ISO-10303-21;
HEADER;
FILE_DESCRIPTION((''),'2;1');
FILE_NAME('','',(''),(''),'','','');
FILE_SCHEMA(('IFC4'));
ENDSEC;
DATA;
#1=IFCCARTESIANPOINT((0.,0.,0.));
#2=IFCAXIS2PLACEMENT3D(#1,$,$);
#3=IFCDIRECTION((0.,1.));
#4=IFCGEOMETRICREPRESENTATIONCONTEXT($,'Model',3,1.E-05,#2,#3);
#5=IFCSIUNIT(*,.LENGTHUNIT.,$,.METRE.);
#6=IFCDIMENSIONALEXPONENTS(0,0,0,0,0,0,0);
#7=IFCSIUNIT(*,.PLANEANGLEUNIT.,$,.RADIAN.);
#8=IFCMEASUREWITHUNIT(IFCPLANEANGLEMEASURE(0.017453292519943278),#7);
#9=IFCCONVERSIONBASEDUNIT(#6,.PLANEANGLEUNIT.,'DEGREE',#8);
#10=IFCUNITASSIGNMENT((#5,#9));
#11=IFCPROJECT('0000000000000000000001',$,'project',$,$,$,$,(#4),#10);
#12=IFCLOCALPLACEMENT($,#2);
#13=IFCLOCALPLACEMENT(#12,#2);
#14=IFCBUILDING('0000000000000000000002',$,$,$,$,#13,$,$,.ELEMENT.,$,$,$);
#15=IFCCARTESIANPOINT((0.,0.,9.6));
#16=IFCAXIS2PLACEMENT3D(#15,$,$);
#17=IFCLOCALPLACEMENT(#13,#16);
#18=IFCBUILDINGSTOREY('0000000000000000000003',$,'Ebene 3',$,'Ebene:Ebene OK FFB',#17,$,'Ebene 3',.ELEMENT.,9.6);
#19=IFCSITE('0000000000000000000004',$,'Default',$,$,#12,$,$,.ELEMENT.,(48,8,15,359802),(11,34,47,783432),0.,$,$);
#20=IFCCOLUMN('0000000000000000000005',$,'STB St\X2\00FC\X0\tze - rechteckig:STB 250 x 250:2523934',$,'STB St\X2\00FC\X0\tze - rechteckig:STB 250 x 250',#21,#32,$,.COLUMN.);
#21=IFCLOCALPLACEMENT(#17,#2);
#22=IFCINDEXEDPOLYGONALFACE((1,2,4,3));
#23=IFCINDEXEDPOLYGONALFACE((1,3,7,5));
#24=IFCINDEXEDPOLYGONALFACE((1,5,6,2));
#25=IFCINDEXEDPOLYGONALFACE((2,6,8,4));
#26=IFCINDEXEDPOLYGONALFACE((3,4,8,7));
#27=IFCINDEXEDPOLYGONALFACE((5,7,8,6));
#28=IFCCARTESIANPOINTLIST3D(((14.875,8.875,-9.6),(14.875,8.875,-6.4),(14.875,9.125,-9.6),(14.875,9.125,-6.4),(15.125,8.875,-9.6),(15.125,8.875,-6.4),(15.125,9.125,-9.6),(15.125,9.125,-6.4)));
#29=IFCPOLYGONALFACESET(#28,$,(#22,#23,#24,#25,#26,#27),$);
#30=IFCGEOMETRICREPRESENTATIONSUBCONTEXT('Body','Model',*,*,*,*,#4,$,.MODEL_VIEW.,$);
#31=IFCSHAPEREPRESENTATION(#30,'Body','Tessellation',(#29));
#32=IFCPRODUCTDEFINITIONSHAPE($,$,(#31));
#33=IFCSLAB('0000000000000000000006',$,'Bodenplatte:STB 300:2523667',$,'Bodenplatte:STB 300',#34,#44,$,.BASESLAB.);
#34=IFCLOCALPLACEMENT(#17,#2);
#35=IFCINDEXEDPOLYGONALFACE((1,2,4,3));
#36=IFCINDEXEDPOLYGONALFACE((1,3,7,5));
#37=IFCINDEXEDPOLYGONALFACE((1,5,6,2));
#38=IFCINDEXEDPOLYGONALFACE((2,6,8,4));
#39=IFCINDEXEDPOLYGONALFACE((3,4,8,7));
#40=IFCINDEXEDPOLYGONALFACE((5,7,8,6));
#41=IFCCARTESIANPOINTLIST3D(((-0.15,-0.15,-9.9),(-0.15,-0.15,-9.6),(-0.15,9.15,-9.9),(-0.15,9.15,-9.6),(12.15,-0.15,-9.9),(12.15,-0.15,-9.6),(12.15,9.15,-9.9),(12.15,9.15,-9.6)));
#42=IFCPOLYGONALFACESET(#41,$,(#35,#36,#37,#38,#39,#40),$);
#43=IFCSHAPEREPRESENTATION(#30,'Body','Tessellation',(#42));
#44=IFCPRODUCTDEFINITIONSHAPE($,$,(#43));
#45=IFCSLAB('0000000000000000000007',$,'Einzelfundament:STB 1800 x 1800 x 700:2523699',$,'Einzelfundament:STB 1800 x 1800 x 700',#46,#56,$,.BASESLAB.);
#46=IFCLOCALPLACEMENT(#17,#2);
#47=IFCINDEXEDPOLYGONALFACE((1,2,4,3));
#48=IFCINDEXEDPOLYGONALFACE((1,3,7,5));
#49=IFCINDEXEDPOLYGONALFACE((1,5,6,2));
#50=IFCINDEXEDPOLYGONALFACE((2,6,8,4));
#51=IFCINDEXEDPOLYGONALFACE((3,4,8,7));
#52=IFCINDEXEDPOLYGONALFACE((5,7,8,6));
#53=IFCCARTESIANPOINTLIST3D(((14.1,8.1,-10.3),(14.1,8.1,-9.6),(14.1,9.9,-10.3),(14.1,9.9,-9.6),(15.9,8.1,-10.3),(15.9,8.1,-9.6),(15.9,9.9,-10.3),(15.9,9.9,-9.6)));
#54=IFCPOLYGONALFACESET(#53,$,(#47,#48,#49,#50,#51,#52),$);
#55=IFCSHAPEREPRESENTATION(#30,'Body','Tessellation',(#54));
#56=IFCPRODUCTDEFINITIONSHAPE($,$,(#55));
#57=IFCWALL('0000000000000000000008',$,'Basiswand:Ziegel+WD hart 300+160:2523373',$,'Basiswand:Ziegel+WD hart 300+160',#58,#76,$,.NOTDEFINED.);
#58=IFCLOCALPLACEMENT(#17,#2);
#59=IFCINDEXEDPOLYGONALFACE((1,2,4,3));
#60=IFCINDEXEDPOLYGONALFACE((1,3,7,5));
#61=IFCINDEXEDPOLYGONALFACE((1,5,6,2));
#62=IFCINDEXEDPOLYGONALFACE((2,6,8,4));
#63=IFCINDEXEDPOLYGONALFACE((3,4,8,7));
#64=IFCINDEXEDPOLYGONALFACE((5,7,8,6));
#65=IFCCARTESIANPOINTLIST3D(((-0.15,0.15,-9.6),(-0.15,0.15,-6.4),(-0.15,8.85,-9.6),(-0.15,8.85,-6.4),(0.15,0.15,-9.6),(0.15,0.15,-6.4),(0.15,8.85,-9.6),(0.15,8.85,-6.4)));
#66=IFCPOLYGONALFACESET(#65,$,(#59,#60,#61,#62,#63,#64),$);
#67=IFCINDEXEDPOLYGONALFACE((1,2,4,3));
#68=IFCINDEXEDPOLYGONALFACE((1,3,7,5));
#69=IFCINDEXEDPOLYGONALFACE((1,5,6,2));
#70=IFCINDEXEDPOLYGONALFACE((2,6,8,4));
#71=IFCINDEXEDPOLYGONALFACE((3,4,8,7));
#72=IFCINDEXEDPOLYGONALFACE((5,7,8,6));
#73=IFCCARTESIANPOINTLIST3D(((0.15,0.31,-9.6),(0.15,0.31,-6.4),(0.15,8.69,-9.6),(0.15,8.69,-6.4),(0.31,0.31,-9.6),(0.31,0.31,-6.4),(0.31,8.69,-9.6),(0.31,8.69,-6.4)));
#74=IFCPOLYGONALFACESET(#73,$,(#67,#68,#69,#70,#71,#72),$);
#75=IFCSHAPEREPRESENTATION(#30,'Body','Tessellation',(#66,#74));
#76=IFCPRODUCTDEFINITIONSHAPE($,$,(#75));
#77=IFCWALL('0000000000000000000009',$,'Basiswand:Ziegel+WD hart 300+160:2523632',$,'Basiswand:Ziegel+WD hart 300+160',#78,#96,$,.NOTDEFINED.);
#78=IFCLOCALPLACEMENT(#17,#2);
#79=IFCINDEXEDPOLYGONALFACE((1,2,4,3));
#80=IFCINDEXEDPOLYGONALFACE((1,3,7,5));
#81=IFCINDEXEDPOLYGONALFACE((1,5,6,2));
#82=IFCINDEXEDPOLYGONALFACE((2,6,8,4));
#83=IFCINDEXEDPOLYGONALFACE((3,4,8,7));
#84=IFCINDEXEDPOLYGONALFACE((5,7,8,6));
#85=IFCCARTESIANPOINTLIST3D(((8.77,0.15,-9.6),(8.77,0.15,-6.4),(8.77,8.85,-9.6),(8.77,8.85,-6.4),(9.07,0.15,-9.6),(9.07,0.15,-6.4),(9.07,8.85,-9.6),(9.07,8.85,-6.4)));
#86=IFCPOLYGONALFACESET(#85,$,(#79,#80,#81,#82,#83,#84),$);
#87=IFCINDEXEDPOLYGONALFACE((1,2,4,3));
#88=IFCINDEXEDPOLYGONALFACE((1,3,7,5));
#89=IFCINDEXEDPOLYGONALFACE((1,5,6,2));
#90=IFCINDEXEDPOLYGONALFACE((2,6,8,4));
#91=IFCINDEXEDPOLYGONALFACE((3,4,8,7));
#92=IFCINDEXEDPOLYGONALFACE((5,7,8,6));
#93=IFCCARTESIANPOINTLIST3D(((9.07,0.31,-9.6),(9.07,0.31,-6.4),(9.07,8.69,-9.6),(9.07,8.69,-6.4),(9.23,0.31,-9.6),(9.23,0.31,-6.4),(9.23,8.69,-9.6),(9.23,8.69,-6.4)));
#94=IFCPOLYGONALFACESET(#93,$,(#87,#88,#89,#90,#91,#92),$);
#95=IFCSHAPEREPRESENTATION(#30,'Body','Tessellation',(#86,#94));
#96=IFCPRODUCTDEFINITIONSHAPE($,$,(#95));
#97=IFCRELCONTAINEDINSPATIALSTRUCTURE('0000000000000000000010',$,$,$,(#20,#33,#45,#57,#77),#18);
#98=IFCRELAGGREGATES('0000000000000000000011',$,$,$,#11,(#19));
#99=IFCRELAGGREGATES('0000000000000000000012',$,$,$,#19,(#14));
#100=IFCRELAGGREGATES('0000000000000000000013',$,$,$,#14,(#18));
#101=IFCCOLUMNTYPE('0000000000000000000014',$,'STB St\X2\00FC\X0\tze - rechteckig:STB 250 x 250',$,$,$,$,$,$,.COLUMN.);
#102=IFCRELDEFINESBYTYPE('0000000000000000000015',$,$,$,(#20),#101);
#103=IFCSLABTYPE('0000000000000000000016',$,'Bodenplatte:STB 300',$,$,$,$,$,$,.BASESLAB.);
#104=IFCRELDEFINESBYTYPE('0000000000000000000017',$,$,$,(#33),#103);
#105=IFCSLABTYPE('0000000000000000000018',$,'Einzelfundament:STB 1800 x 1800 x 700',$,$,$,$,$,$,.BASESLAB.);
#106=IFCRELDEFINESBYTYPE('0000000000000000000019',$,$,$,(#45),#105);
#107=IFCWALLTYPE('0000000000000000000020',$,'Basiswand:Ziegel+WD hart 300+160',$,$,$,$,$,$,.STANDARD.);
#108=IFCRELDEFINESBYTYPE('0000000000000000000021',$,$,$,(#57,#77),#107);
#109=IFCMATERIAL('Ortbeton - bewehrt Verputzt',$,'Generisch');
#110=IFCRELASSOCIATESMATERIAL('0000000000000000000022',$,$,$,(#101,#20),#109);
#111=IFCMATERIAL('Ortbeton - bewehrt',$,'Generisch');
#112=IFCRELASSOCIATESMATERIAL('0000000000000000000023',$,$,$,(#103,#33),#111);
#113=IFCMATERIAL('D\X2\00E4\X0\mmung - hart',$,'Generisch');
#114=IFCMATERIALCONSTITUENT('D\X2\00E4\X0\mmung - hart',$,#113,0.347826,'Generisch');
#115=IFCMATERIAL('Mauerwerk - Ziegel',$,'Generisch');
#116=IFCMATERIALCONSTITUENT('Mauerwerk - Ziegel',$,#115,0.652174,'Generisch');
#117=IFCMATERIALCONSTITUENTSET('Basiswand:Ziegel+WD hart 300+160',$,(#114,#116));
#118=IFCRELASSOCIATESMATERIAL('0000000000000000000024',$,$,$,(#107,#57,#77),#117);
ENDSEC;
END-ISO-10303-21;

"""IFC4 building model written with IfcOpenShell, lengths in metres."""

from ifc_helpers import new_model, entity, si_unit, converted_unit, direction, frame, origin, place, context, subcontext, project, spatial, indexed_curve, outline, extrude, source, transform, mapped, material, constituent, constituent_set, type_object, type_shapes, element, save


model = new_model("IFC4")

# Units and contexts
model_context = context("Model", 3, precision=1e-05, world=origin(), true_north=direction((0.0, 1.0)))
body_context = subcontext(model_context, "Body", "Model", "MODEL_VIEW")
ifc_project = project(units=[si_unit("LENGTHUNIT", "METRE"), converted_unit("PLANEANGLEUNIT", "DEGREE", entity("IfcPlaneAngleMeasure", 0.017453292519943278), si_unit("PLANEANGLEUNIT", "RADIAN"), dimensions=[0, 0, 0, 0, 0, 0, 0])], contexts=[model_context])

# Site, building, storey
site_placement = place(None, origin())
site = spatial("IfcSite", under=ifc_project, at=site_placement, Name="Default", CompositionType="ELEMENT", RefLatitude=(48, 8, 15, 359802), RefLongitude=(11, 34, 47, 783432), RefElevation=0.0)
building_placement = place(site_placement, origin())
building = spatial("IfcBuilding", under=site, at=building_placement, CompositionType="ELEMENT")
storey_placement = place(building_placement, frame((0.0, 0.0, 9.6)))
storey = spatial("IfcBuildingStorey", under=building, at=storey_placement, Name="Ebene 3", ObjectType="Ebene:Ebene OK FFB", LongName="Ebene 3", CompositionType="ELEMENT", Elevation=9.6)

# Column
ifc_material_1 = material(Name="Ortbeton - bewehrt Verputzt", Category="Generisch")
column_type = type_object("IfcColumnType", Name="STB Stütze - rechteckig:STB 250 x 250", PredefinedType="COLUMN", material=ifc_material_1)
shared_shape = source(origin(), body_context, "Body", "SweptSolid", [
    extrude(outline(indexed_curve([(-0.125, -0.125), (0.125, -0.125), (0.125, 0.125), (-0.125, 0.125), (-0.125, -0.125)], self_intersect=False)), frame((0.0, 0.0, 0.0), z_axis=(0.0, 0.0, 1.0), x_axis=(-1.0, 0.0, 0.0)), (0.0, 0.0, 1.0), 3.2),
])
type_shapes(column_type, [shared_shape])
column_placement = place(storey_placement, frame((15.0, 9.0, -9.6)))
element("IfcColumn", 1, at=column_placement, inside=storey, type_object=column_type, material=ifc_material_1, Name="STB Stütze - rechteckig:STB 250 x 250:2523934", ObjectType="STB Stütze - rechteckig:STB 250 x 250", PredefinedType="COLUMN", context=body_context, shape_type="MappedRepresentation", body=[
    mapped(shared_shape, transform((0.0, 0.0, 0.0), scale=1.0)),
])

# Slabs
ifc_material_2 = material(Name="Ortbeton - bewehrt", Category="Generisch")
slab_type_1 = type_object("IfcSlabType", Name="Bodenplatte:STB 300", PredefinedType="BASESLAB", material=ifc_material_2)
slab_1_placement = place(storey_placement, origin())
element("IfcSlab", 2, at=slab_1_placement, inside=storey, type_object=slab_type_1, material=ifc_material_2, Name="Bodenplatte:STB 300:2523667", ObjectType="Bodenplatte:STB 300", PredefinedType="BASESLAB", context=body_context, shape_type="SweptSolid", body=[
    extrude(outline(indexed_curve([(-4.65, -6.15), (4.65, -6.15), (4.65, 6.15), (-4.65, 6.15), (-4.65, -6.15)], self_intersect=False)), frame((6.0, 4.5, -9.6), z_axis=(0.0, 0.0, -1.0), x_axis=(0.0, 1.0, 0.0)), (0.0, 0.0, 1.0), 0.3),
])
slab_type_2 = type_object("IfcSlabType", Name="Einzelfundament:STB 1800 x 1800 x 700", PredefinedType="BASESLAB")
slab_2_placement = place(storey_placement, origin())
element("IfcSlab", 3, at=slab_2_placement, inside=storey, type_object=slab_type_2, Name="Einzelfundament:STB 1800 x 1800 x 700:2523699", ObjectType="Einzelfundament:STB 1800 x 1800 x 700", PredefinedType="BASESLAB", context=body_context, shape_type="SweptSolid", body=[
    extrude(outline(indexed_curve([(-0.9, -0.9), (0.9, -0.9), (0.9, 0.9), (-0.9, 0.9), (-0.9, -0.9)], self_intersect=False)), frame((15.0, 9.0, -10.3), z_axis=(0.0, 0.0, 1.0), x_axis=(-1.0, 0.0, 0.0)), (0.0, 0.0, 1.0), 0.7),
])

# Shared definitions
ifc_material_3 = material(Name="Dämmung - hart", Category="Generisch")
ifc_constituent_1 = constituent(ifc_material_3, Name="Dämmung - hart", Category="Generisch", fraction=0.347826)
ifc_material_4 = material(Name="Mauerwerk - Ziegel", Category="Generisch")
ifc_constituent_2 = constituent(ifc_material_4, Name="Mauerwerk - Ziegel", Category="Generisch", fraction=0.652174)
ifc_constituent_set = constituent_set(constituents=[ifc_constituent_1, ifc_constituent_2], Name="Basiswand:Ziegel+WD hart 300+160")
wall_type = type_object("IfcWallType", Name="Basiswand:Ziegel+WD hart 300+160", PredefinedType="STANDARD", material=ifc_constituent_set)

# Walls
wall_1_placement = place(storey_placement, frame((0.08, 8.69, -9.6), z_axis=(0.0, 0.0, 1.0), x_axis=(0.0, -1.0, 0.0)))
element("IfcWall", 4, at=wall_1_placement, inside=storey, type_object=wall_type, material=ifc_constituent_set, Name="Basiswand:Ziegel+WD hart 300+160:2523373", ObjectType="Basiswand:Ziegel+WD hart 300+160", PredefinedType="NOTDEFINED", context=body_context, shape_type="SweptSolid", body=[
    extrude(outline(indexed_curve([(-0.15, -4.35), (0.15, -4.35), (0.15, 4.35), (-0.15, 4.35), (-0.15, -4.35)], self_intersect=False)), frame((4.19, -0.08, 0.0), z_axis=(0.0, 0.0, 1.0), x_axis=(0.0, 1.0, 0.0)), (0.0, 0.0, 1.0), 3.2),
    extrude(outline(indexed_curve([(-0.08, -4.19), (0.08, -4.19), (0.08, 4.19), (-0.08, 4.19), (-0.08, -4.19)], self_intersect=False)), frame((4.19, 0.15, 0.0), z_axis=(0.0, 0.0, 1.0), x_axis=(0.0, -1.0, 0.0)), (0.0, 0.0, 1.0), 3.2),
])
wall_2_placement = place(storey_placement, frame((9.0, 8.69, -9.6), z_axis=(0.0, 0.0, 1.0), x_axis=(0.0, -1.0, 0.0)))
element("IfcWall", 5, at=wall_2_placement, inside=storey, type_object=wall_type, material=ifc_constituent_set, Name="Basiswand:Ziegel+WD hart 300+160:2523632", ObjectType="Basiswand:Ziegel+WD hart 300+160", PredefinedType="NOTDEFINED", context=body_context, shape_type="SweptSolid", body=[
    extrude(outline(indexed_curve([(-0.15, -4.35), (0.15, -4.35), (0.15, 4.35), (-0.15, 4.35), (-0.15, -4.35)], self_intersect=False)), frame((4.19, -0.08, 0.0), z_axis=(0.0, 0.0, 1.0), x_axis=(0.0, 1.0, 0.0)), (0.0, 0.0, 1.0), 3.2),
    extrude(outline(indexed_curve([(-0.08, -4.19), (0.08, -4.19), (0.08, 4.19), (-0.08, 4.19), (-0.08, -4.19)], self_intersect=False)), frame((4.19, 0.15, 0.0), z_axis=(0.0, 0.0, 1.0), x_axis=(0.0, -1.0, 0.0)), (0.0, 0.0, 1.0), 3.2),
])

save(model, "model.ifc")
